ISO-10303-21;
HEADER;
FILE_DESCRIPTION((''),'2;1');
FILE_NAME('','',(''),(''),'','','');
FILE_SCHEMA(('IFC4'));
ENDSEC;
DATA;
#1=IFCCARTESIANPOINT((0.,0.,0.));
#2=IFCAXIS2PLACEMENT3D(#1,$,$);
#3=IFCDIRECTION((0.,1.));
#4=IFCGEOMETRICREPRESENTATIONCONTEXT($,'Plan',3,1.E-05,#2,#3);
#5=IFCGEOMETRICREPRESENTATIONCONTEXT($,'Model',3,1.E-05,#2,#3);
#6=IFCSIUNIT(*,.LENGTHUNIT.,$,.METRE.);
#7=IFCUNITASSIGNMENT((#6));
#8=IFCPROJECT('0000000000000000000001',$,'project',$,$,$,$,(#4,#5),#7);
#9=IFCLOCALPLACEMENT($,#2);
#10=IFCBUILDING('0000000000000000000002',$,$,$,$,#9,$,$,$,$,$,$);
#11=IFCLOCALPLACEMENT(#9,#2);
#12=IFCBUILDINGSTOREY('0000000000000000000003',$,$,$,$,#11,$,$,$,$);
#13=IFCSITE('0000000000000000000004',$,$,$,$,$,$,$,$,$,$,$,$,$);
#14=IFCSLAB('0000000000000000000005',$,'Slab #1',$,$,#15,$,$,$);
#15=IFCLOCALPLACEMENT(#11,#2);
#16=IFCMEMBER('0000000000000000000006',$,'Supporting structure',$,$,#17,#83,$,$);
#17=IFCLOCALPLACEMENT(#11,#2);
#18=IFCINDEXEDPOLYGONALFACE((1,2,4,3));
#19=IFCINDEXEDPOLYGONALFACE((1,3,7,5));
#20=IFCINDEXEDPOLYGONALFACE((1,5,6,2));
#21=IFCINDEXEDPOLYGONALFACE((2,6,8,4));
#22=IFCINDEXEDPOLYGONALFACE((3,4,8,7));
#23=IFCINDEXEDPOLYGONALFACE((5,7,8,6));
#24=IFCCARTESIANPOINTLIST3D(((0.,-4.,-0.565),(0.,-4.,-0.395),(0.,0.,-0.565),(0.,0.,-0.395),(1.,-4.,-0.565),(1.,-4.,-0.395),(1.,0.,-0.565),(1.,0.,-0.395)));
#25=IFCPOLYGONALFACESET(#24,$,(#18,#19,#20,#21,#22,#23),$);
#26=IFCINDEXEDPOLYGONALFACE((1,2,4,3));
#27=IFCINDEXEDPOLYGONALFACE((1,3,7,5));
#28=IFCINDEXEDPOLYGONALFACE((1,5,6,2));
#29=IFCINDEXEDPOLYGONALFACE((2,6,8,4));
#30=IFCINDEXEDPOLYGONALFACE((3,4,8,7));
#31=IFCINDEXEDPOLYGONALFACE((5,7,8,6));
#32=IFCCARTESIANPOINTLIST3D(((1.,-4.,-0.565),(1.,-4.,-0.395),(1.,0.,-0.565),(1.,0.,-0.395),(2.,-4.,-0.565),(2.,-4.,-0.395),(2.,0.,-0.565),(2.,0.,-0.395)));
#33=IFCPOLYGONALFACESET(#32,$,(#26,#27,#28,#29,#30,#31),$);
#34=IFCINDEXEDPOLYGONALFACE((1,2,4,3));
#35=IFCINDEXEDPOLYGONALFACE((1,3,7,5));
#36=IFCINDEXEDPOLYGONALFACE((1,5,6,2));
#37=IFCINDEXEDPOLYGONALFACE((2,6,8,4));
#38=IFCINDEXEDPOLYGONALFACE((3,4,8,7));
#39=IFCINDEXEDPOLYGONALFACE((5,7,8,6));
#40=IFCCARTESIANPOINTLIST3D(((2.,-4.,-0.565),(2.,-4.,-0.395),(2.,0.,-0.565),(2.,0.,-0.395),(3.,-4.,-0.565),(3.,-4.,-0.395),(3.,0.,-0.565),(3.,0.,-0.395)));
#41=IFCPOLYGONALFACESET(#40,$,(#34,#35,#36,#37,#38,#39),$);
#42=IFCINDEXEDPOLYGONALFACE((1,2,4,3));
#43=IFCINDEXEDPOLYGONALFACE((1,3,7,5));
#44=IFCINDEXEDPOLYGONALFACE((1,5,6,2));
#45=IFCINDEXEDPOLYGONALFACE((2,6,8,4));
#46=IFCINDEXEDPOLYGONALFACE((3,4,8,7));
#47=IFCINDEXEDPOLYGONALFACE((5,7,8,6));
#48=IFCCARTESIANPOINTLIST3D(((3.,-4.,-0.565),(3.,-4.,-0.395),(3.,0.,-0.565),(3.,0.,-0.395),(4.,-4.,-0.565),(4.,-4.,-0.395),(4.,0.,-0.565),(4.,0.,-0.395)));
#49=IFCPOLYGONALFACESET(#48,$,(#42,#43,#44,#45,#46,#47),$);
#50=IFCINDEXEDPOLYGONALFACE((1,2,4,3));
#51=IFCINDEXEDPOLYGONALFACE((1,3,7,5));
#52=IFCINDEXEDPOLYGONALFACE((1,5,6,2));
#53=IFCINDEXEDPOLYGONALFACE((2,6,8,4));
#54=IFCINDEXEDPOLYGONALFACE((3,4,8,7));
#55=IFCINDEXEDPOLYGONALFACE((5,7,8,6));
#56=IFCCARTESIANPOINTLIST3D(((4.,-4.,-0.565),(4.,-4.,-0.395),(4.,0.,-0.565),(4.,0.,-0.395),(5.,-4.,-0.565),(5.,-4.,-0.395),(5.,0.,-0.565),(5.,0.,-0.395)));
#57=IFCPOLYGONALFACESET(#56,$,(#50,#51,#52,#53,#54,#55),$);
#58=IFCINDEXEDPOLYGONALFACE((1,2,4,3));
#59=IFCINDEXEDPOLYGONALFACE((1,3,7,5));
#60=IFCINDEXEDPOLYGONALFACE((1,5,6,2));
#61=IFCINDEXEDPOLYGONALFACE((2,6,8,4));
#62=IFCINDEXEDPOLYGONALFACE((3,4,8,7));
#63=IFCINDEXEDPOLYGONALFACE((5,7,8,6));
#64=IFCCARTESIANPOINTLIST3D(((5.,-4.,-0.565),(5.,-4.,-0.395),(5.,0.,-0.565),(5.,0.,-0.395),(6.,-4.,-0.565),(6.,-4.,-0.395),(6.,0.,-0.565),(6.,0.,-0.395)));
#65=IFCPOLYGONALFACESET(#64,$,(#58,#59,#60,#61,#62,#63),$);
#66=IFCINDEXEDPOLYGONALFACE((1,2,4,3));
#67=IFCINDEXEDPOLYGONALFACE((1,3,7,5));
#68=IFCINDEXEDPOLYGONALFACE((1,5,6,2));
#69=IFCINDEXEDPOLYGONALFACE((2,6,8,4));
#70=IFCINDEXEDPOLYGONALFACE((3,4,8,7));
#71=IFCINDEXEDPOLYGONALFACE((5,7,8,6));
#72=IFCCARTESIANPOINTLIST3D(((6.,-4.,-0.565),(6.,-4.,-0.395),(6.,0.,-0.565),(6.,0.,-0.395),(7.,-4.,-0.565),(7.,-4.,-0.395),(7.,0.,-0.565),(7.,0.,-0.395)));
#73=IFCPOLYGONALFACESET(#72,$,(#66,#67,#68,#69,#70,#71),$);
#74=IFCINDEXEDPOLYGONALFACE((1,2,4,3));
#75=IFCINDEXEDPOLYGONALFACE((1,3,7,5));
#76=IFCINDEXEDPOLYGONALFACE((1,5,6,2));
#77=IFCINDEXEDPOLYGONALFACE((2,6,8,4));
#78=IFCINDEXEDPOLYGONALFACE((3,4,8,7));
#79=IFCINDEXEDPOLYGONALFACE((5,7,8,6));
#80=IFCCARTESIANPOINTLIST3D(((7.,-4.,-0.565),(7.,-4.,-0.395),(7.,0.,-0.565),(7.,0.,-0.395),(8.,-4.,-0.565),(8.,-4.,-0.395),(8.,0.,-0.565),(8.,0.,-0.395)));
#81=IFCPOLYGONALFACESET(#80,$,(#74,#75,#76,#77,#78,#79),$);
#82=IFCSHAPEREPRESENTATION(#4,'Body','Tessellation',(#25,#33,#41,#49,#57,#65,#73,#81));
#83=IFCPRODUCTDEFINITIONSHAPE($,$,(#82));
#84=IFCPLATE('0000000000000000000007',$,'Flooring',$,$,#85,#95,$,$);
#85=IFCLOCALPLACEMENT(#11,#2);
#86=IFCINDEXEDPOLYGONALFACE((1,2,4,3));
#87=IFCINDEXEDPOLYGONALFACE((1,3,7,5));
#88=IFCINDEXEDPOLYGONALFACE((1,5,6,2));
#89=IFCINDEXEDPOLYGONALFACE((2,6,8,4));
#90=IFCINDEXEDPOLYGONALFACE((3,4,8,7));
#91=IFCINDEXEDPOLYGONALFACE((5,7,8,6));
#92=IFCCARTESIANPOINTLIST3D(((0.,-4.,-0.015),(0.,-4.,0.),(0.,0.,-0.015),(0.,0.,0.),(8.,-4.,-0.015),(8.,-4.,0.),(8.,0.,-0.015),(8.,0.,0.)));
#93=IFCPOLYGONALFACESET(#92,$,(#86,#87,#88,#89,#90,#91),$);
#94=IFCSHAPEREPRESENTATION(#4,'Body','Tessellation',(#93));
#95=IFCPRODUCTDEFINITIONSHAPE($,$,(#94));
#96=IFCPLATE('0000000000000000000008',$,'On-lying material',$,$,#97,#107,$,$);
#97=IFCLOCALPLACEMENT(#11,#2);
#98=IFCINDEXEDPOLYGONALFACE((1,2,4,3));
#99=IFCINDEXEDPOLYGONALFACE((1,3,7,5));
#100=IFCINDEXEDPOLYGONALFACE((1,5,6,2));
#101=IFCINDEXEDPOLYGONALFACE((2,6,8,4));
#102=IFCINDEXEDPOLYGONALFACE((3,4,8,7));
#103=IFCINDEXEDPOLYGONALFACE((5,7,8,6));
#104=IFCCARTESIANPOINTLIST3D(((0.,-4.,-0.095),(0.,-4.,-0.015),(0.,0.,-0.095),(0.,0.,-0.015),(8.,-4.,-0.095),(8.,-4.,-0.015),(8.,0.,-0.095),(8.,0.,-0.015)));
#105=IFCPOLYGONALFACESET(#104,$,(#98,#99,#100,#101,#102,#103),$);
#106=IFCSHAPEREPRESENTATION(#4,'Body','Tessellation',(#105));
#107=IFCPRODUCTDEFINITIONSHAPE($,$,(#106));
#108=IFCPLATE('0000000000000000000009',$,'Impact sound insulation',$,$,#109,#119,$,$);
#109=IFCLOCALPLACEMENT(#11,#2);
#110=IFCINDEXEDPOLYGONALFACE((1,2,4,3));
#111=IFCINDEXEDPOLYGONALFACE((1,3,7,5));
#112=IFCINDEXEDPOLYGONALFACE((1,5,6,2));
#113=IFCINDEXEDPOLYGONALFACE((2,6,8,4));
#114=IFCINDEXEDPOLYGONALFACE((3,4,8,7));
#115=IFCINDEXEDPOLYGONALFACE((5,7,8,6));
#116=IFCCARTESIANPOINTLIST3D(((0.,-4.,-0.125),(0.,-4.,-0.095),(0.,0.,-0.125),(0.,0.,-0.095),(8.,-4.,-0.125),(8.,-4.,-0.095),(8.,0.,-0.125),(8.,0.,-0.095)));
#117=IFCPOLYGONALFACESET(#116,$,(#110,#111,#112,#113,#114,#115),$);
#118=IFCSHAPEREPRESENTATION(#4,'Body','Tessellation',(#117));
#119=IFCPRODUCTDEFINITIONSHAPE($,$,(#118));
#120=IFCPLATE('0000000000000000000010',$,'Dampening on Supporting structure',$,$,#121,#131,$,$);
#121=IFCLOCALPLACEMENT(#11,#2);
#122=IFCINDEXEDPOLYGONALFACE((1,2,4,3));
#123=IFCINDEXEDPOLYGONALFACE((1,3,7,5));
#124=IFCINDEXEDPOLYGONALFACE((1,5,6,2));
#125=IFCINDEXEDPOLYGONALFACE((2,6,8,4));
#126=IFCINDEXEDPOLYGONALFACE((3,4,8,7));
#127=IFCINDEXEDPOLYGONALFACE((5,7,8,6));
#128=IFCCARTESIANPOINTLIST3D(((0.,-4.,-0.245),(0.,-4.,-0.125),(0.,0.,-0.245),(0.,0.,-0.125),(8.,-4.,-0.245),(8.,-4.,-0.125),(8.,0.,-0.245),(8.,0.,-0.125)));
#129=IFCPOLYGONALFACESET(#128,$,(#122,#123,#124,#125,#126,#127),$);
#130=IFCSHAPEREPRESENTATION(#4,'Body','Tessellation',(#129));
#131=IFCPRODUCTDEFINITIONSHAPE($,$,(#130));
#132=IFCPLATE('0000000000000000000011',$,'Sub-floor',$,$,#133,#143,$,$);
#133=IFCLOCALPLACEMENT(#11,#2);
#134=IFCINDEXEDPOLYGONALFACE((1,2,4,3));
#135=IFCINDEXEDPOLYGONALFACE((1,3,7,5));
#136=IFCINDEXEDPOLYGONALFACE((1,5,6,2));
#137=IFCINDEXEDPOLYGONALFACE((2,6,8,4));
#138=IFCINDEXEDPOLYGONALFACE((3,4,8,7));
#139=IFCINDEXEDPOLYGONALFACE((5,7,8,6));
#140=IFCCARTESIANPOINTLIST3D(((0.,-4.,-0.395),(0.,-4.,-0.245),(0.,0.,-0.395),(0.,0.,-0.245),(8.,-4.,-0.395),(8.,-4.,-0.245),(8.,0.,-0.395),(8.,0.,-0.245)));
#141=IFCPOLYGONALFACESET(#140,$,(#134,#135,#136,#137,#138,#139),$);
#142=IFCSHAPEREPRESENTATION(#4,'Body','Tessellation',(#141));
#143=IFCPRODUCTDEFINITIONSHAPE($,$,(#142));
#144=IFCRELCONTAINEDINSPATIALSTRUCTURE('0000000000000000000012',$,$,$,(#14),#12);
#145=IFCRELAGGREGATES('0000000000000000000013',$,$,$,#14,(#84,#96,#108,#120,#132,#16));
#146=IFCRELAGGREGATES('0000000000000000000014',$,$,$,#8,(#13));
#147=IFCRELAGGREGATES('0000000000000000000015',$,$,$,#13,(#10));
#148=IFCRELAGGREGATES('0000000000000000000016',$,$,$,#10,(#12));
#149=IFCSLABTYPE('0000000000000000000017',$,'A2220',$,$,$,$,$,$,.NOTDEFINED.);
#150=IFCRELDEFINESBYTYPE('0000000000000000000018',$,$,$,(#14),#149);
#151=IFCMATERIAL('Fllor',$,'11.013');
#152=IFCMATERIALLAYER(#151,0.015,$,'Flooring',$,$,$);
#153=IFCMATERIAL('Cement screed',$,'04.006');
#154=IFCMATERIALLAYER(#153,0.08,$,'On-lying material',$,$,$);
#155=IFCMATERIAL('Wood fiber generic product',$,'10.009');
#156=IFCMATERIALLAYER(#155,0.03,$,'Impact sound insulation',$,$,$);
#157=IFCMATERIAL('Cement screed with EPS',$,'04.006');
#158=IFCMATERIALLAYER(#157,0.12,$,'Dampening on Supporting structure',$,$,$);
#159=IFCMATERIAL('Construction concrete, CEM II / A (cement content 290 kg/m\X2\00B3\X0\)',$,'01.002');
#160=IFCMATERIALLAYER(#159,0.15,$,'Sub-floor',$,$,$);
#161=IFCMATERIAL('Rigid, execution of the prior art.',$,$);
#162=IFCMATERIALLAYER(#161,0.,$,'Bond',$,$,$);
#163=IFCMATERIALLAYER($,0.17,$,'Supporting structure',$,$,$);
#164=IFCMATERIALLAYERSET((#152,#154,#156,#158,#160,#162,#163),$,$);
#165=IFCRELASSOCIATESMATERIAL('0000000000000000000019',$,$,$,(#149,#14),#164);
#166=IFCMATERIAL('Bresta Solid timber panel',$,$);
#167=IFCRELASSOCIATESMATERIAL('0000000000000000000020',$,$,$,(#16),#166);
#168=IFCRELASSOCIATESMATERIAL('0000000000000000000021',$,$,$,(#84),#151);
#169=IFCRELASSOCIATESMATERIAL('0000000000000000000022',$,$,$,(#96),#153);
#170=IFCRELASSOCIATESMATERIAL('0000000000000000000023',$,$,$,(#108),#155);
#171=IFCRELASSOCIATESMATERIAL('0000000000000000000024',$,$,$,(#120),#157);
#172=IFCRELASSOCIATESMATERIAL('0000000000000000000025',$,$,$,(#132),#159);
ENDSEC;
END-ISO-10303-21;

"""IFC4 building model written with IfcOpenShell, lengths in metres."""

from ifc_helpers import new_model, si_unit, direction, frame, frame_2d, origin, origin_with_axes, place, context, project, spatial, rectangle, extrude, material, layer, layer_set, type_object, element, aggregate, save


model = new_model("IFC4")

# Units and contexts
plan_context = context("Plan", 3, precision=1e-05, world=origin(), true_north=direction((0.0, 1.0)))
model_context = context("Model", 3, precision=1e-05, world=origin(), true_north=direction((0.0, 1.0)))
ifc_project = project(units=[si_unit("LENGTHUNIT", "METRE")], contexts=[plan_context, model_context])

# Site, building, storey
site = spatial("IfcSite", under=ifc_project)
building_placement = place(None, origin())
building = spatial("IfcBuilding", under=site, at=building_placement)
storey_placement = place(building_placement, origin())
storey = spatial("IfcBuildingStorey", under=building, at=storey_placement)

# Slab, member, plates
ifc_material_1 = material(Name="Fllor", Category="11.013")
ifc_layer_1 = layer(ifc_material_1, 0.015, Name="Flooring")
ifc_material_2 = material(Name="Cement screed", Category="04.006")
ifc_layer_2 = layer(ifc_material_2, 0.08, Name="On-lying material")
ifc_material_3 = material(Name="Wood fiber generic product", Category="10.009")
ifc_layer_3 = layer(ifc_material_3, 0.03, Name="Impact sound insulation")
ifc_material_4 = material(Name="Cement screed with EPS", Category="04.006")
ifc_layer_4 = layer(ifc_material_4, 0.12, Name="Dampening on Supporting structure")
ifc_material_5 = material(Name="Construction concrete, CEM II / A (cement content 290 kg/m³)", Category="01.002")
ifc_layer_5 = layer(ifc_material_5, 0.15, Name="Sub-floor")
ifc_material_6 = material(Name="Rigid, execution of the prior art.")
ifc_layer_6 = layer(ifc_material_6, 0.0, Name="Bond")
ifc_layer_7 = layer(None, 0.17, Name="Supporting structure")
ifc_layer_set = layer_set([ifc_layer_1, ifc_layer_2, ifc_layer_3, ifc_layer_4, ifc_layer_5, ifc_layer_6, ifc_layer_7])
slab_type = type_object("IfcSlabType", Name="A2220", PredefinedType="NOTDEFINED", material=ifc_layer_set)
slab_placement = place(None, frame((0.0, 0.0, 0.0), z_axis=(0.0, 0.0, -1.0), x_axis=(1.0, 0.0, 0.0)))
slab = element("IfcSlab", 1, at=slab_placement, inside=storey, type_object=slab_type, material=ifc_layer_set, Name="Slab #1")
ifc_material_7 = material(Name="Bresta Solid timber panel")
member_placement = place(slab_placement, origin())
member = element("IfcMember", 2, at=member_placement, material=ifc_material_7, Name="Supporting structure", context=plan_context, shape_type="SweptSolid", body=[
    extrude(rectangle(XDim=1.0, YDim=0.17, at=frame_2d((0.5, 0.085), x_axis=(1.0, 0.0))), frame((0.0, 4.0, 0.395), z_axis=(0.0, -1.0, 0.0), x_axis=(1.0, 0.0, 0.0)), (0.0, 0.0, 1.0), 4.0),
    extrude(rectangle(XDim=1.0, YDim=0.17, at=frame_2d((0.5, 0.085), x_axis=(1.0, 0.0))), frame((1.0, 4.0, 0.395), z_axis=(0.0, -1.0, 0.0), x_axis=(1.0, 0.0, 0.0)), (0.0, 0.0, 1.0), 4.0),
    extrude(rectangle(XDim=1.0, YDim=0.17, at=frame_2d((0.5, 0.085), x_axis=(1.0, 0.0))), frame((2.0, 4.0, 0.395), z_axis=(0.0, -1.0, 0.0), x_axis=(1.0, 0.0, 0.0)), (0.0, 0.0, 1.0), 4.0),
    extrude(rectangle(XDim=1.0, YDim=0.17, at=frame_2d((0.5, 0.085), x_axis=(1.0, 0.0))), frame((3.0, 4.0, 0.395), z_axis=(0.0, -1.0, 0.0), x_axis=(1.0, 0.0, 0.0)), (0.0, 0.0, 1.0), 4.0),
    extrude(rectangle(XDim=1.0, YDim=0.17, at=frame_2d((0.5, 0.085), x_axis=(1.0, 0.0))), frame((4.0, 4.0, 0.395), z_axis=(0.0, -1.0, 0.0), x_axis=(1.0, 0.0, 0.0)), (0.0, 0.0, 1.0), 4.0),
    extrude(rectangle(XDim=1.0, YDim=0.17, at=frame_2d((0.5, 0.085), x_axis=(1.0, 0.0))), frame((5.0, 4.0, 0.395), z_axis=(0.0, -1.0, 0.0), x_axis=(1.0, 0.0, 0.0)), (0.0, 0.0, 1.0), 4.0),
    extrude(rectangle(XDim=1.0, YDim=0.17, at=frame_2d((0.5, 0.085), x_axis=(1.0, 0.0))), frame((6.0, 4.0, 0.395), z_axis=(0.0, -1.0, 0.0), x_axis=(1.0, 0.0, 0.0)), (0.0, 0.0, 1.0), 4.0),
    extrude(rectangle(XDim=1.0, YDim=0.17, at=frame_2d((0.5, 0.085), x_axis=(1.0, 0.0))), frame((7.0, 4.0, 0.395), z_axis=(0.0, -1.0, 0.0), x_axis=(1.0, 0.0, 0.0)), (0.0, 0.0, 1.0), 4.0),
])
plate_1_placement = place(slab_placement, origin())
plate_1 = element("IfcPlate", 3, at=plate_1_placement, material=ifc_material_1, Name="Flooring", context=plan_context, shape_type="SweptSolid", body=[
    extrude(rectangle(XDim=8.0, YDim=4.0, at=frame_2d((4.0, 2.0), x_axis=(1.0, 0.0))), origin_with_axes(), (0.0, 0.0, 1.0), 0.015),
])
plate_2_placement = place(slab_placement, origin())
plate_2 = element("IfcPlate", 4, at=plate_2_placement, material=ifc_material_2, Name="On-lying material", context=plan_context, shape_type="SweptSolid", body=[
    extrude(rectangle(XDim=8.0, YDim=4.0, at=frame_2d((4.0, 2.0), x_axis=(1.0, 0.0))), frame((0.0, 0.0, 0.015), z_axis=(0.0, 0.0, 1.0), x_axis=(1.0, 0.0, 0.0)), (0.0, 0.0, 1.0), 0.08),
])
plate_3_placement = place(slab_placement, origin())
plate_3 = element("IfcPlate", 5, at=plate_3_placement, material=ifc_material_3, Name="Impact sound insulation", context=plan_context, shape_type="SweptSolid", body=[
    extrude(rectangle(XDim=8.0, YDim=4.0, at=frame_2d((4.0, 2.0), x_axis=(1.0, 0.0))), frame((0.0, 0.0, 0.095), z_axis=(0.0, 0.0, 1.0), x_axis=(1.0, 0.0, 0.0)), (0.0, 0.0, 1.0), 0.03),
])
plate_4_placement = place(slab_placement, origin())
plate_4 = element("IfcPlate", 6, at=plate_4_placement, material=ifc_material_4, Name="Dampening on Supporting structure", context=plan_context, shape_type="SweptSolid", body=[
    extrude(rectangle(XDim=8.0, YDim=4.0, at=frame_2d((4.0, 2.0), x_axis=(1.0, 0.0))), frame((0.0, 0.0, 0.125), z_axis=(0.0, 0.0, 1.0), x_axis=(1.0, 0.0, 0.0)), (0.0, 0.0, 1.0), 0.12),
])
plate_5_placement = place(slab_placement, origin())
plate_5 = element("IfcPlate", 7, at=plate_5_placement, material=ifc_material_5, Name="Sub-floor", context=plan_context, shape_type="SweptSolid", body=[
    extrude(rectangle(XDim=8.0, YDim=4.0, at=frame_2d((4.0, 2.0), x_axis=(1.0, 0.0))), frame((0.0, 0.0, 0.245), z_axis=(0.0, 0.0, 1.0), x_axis=(1.0, 0.0, 0.0)), (0.0, 0.0, 1.0), 0.15),
])
aggregate(slab, [plate_1, plate_2, plate_3, plate_4, plate_5, member])

save(model, "model.ifc")
